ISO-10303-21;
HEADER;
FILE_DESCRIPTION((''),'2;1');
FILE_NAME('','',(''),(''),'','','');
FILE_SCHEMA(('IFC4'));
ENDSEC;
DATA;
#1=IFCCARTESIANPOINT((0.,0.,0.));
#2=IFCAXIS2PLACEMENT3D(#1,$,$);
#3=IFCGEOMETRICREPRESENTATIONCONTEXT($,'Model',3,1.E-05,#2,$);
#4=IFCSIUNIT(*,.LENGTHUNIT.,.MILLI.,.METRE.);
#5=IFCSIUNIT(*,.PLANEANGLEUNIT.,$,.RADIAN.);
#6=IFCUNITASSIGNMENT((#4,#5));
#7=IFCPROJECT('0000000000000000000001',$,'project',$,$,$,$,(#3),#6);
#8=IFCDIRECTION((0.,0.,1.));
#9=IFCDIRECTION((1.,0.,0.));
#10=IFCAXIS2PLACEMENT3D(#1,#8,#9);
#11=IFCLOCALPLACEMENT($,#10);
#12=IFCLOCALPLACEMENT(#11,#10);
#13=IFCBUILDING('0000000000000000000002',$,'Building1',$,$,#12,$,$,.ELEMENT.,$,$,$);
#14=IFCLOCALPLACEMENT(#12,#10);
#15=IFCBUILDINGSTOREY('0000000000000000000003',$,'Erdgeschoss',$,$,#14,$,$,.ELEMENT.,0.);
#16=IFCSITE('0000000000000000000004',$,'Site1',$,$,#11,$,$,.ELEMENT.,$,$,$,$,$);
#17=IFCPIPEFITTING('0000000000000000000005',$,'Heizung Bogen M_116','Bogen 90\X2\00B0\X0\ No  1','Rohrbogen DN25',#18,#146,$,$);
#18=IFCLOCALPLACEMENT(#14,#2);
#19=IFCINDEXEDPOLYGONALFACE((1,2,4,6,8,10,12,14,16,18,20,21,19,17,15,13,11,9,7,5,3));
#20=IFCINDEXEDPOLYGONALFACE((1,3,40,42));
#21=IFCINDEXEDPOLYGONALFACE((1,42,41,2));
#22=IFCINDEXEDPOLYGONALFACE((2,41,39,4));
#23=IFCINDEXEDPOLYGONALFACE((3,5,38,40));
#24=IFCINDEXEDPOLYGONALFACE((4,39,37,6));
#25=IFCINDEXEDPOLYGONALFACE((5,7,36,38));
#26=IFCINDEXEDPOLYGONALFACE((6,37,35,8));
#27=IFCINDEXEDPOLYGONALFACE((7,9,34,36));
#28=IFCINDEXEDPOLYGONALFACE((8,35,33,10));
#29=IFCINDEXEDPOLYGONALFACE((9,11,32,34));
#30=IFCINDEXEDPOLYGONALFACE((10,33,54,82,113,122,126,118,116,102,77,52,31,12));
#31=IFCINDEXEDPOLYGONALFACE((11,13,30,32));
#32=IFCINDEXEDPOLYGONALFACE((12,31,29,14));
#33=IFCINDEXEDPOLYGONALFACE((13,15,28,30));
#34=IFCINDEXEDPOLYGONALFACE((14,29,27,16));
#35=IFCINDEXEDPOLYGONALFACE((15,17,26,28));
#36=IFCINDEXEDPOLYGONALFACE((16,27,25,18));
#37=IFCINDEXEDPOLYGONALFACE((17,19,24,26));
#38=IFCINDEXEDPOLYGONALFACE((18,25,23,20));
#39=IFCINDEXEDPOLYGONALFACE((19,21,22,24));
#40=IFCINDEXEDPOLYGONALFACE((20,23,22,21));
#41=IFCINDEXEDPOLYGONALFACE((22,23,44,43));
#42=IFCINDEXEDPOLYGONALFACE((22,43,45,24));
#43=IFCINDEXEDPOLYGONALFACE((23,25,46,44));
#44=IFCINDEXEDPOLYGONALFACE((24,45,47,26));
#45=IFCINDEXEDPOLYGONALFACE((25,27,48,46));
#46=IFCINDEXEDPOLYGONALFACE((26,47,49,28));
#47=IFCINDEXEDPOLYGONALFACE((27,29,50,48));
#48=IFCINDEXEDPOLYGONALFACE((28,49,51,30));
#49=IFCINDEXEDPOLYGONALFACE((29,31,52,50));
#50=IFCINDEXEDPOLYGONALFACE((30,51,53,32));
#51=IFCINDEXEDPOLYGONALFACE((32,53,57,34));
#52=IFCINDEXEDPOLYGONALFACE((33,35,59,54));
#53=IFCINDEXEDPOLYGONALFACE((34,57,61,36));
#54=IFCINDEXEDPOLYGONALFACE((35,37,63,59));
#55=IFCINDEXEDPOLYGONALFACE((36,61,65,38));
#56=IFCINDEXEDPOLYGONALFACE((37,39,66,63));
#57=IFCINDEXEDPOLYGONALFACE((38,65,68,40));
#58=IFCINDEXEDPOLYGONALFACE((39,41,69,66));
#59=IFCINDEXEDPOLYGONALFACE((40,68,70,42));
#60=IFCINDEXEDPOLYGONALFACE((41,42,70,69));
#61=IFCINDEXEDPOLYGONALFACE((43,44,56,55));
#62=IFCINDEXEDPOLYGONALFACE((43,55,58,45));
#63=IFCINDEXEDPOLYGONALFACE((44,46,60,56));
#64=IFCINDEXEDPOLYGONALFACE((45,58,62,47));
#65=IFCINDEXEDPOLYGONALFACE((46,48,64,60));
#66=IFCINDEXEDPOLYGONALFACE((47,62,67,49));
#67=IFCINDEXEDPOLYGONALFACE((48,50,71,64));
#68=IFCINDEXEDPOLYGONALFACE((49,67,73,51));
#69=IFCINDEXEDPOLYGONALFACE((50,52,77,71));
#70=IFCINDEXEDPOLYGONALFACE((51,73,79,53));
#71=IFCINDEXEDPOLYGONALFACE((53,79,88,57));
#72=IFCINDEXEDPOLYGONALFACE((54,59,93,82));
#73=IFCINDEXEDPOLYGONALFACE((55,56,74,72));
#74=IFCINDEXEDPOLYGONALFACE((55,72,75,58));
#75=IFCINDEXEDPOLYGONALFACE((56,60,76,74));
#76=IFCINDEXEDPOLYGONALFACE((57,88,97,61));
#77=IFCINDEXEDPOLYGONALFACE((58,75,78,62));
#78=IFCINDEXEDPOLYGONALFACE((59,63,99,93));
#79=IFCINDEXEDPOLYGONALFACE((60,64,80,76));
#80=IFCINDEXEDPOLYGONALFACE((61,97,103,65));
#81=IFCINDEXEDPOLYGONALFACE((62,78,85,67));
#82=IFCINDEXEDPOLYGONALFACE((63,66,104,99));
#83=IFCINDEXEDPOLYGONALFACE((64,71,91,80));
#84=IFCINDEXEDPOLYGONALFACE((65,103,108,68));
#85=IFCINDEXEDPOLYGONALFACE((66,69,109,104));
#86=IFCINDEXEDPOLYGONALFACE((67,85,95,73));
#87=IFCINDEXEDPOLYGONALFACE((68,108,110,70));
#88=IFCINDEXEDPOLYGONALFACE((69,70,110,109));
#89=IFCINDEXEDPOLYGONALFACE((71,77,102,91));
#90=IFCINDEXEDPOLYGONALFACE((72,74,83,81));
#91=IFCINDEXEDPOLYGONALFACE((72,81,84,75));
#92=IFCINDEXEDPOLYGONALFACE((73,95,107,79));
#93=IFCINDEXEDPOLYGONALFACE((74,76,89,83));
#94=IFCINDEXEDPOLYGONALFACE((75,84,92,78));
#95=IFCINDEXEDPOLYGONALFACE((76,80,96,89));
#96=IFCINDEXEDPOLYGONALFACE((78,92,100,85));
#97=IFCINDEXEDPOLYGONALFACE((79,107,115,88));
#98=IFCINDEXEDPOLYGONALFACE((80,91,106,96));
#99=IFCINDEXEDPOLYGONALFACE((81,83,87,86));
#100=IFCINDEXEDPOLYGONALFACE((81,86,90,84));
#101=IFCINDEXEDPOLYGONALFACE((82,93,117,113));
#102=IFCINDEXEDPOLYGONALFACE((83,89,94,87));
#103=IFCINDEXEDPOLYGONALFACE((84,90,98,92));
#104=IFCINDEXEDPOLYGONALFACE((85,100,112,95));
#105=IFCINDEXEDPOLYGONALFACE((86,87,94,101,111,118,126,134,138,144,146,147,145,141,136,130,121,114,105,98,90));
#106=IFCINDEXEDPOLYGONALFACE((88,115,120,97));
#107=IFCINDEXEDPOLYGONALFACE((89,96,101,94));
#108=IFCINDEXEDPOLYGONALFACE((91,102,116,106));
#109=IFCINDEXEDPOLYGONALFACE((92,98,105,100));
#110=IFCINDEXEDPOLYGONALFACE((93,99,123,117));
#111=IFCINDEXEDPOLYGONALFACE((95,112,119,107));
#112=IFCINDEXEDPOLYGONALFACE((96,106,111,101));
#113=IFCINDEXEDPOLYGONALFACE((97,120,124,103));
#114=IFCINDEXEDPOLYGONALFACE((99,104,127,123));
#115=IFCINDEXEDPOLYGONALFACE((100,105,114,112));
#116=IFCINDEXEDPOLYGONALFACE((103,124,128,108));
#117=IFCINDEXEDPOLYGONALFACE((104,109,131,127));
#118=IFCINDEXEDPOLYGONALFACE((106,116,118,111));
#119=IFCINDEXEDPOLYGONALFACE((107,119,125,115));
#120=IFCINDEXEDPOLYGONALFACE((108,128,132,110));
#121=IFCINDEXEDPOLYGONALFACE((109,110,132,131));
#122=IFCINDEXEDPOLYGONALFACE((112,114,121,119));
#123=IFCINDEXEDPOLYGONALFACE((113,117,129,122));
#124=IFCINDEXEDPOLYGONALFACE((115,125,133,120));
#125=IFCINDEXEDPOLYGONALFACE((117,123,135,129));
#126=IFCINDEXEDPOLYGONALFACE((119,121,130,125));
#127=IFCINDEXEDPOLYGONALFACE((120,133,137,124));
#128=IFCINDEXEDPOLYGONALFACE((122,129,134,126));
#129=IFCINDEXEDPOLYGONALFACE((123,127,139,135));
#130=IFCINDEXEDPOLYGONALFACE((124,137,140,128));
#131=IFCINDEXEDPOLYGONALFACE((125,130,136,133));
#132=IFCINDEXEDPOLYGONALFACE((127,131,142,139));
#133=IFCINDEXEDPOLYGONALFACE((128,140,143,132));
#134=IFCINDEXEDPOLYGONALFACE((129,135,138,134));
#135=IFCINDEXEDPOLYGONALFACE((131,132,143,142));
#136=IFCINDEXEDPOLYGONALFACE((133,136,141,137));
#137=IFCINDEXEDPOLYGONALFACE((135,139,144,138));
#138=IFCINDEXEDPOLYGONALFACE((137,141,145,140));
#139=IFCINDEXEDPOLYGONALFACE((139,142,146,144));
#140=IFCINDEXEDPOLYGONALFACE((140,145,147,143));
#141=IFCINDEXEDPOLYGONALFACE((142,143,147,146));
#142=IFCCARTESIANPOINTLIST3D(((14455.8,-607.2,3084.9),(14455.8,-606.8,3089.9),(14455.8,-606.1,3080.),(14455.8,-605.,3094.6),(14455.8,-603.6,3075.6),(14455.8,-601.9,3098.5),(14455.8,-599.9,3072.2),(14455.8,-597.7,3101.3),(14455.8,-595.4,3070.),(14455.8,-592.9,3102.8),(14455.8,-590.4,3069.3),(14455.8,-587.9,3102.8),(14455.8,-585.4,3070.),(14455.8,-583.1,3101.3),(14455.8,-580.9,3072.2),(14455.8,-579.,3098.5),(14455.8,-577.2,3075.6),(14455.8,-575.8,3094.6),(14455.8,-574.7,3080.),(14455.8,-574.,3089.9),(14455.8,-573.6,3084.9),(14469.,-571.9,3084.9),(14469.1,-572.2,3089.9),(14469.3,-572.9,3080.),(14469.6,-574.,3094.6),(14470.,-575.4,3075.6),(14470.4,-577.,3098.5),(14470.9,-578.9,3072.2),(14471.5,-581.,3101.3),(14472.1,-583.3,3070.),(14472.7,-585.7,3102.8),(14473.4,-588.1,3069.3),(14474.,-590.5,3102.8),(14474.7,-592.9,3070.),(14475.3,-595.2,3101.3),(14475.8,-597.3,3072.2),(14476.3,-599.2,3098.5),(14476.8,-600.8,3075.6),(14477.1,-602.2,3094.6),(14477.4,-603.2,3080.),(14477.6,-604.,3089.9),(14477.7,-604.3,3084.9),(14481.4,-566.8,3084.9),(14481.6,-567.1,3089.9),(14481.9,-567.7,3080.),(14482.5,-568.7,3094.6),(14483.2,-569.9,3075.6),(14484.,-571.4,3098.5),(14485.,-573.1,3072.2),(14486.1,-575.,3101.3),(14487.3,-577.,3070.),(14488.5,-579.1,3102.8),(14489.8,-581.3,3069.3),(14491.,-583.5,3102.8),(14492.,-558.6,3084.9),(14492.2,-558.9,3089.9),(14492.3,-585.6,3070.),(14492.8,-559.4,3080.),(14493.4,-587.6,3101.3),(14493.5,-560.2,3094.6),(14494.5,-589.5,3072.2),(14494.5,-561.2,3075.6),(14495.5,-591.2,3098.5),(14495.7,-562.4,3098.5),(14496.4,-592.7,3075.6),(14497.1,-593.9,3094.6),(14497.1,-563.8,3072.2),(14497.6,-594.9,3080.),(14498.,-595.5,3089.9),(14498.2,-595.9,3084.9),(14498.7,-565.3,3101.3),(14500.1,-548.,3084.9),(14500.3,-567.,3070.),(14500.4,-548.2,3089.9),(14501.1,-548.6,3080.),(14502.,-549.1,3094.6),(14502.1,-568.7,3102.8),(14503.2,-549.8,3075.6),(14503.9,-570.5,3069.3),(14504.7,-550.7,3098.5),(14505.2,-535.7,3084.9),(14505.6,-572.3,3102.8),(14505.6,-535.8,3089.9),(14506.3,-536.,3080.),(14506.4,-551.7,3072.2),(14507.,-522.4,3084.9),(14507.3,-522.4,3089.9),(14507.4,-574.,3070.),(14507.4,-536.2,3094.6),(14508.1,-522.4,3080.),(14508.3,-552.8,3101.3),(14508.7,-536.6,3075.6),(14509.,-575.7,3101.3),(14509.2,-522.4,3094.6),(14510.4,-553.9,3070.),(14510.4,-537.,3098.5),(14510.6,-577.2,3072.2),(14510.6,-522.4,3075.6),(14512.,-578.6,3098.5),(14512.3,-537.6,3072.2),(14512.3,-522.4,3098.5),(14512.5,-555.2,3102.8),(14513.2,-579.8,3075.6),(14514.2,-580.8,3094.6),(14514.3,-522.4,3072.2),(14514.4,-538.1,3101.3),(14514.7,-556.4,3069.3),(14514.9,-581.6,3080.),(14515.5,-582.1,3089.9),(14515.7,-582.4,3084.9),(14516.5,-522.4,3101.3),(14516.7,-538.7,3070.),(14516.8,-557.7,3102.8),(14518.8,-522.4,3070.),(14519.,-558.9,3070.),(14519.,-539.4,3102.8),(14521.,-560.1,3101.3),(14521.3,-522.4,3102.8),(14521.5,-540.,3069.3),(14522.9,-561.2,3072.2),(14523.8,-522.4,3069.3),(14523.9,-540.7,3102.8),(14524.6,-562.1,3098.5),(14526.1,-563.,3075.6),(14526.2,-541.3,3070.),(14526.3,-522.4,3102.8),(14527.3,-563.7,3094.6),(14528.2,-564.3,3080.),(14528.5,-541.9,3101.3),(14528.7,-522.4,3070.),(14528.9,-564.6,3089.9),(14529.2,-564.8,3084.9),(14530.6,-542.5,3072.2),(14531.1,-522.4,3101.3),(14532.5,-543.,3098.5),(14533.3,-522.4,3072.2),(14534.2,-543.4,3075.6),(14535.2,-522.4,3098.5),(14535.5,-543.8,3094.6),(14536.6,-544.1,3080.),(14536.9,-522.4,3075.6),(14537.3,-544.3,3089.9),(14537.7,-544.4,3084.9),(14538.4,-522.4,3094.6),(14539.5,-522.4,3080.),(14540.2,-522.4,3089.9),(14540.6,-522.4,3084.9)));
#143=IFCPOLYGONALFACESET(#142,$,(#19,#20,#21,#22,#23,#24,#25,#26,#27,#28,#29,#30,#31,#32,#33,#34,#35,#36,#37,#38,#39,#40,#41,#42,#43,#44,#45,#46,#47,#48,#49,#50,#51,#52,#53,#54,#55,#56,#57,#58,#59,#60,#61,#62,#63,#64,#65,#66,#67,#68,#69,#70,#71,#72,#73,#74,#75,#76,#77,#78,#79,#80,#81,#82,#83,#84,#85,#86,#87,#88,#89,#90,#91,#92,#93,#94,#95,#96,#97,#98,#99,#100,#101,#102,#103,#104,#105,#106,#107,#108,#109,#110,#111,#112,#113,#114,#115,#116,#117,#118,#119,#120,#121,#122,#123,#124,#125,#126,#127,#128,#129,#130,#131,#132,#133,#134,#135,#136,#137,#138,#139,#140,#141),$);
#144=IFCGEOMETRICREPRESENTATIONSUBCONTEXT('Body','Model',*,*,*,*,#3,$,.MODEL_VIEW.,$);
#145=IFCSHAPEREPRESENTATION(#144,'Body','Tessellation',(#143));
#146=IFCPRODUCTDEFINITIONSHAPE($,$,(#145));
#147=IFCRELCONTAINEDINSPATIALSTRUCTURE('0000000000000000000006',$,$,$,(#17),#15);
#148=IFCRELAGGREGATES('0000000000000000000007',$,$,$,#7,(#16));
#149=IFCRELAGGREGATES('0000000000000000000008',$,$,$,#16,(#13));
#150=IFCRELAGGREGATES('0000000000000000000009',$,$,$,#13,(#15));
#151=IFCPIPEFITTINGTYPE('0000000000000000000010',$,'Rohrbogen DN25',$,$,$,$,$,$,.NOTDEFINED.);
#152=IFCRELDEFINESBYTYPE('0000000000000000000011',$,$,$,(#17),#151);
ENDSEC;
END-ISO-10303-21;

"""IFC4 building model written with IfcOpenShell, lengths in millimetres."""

from ifc_helpers import new_model, entity, si_unit, frame, origin, origin_with_axes, place, context, subcontext, project, spatial, source, transform, mapped, type_object, element, save


model = new_model("IFC4")

# Units and contexts
model_context = context("Model", 3, precision=1e-05, world=origin())
body_context = subcontext(model_context, "Body", "Model", "MODEL_VIEW")
ifc_project = project(units=[si_unit("LENGTHUNIT", "METRE", prefix="MILLI"), si_unit("PLANEANGLEUNIT", "RADIAN")], contexts=[model_context])

# Site, building, storey
site_placement = place(None, origin_with_axes())
site = spatial("IfcSite", under=ifc_project, at=site_placement, Name="Site1", CompositionType="ELEMENT")
building_placement = place(site_placement, origin_with_axes())
building = spatial("IfcBuilding", under=site, at=building_placement, Name="Building1", CompositionType="ELEMENT")
storey_placement = place(building_placement, origin_with_axes())
storey = spatial("IfcBuildingStorey", under=building, at=storey_placement, Name="Erdgeschoss", CompositionType="ELEMENT", Elevation=0.0)

# Pipe fitting
pipe_fitting_type = type_object("IfcPipeFittingType", Name="Rohrbogen DN25", PredefinedType="NOTDEFINED")
shared_shape_1 = source(origin_with_axes(), body_context, "Body", "SolidModel", [
    entity("IfcRevolvedAreaSolid", entity("IfcCircleProfileDef", "AREA", None, entity("IfcAxis2Placement2D", entity("IfcCartesianPoint", [0.0, 0.0]), entity("IfcDirection", [1.0, 0.0])), 16.9), entity("IfcAxis2Placement3D", entity("IfcCartesianPoint", [-42.4, 25.6, 0.0]), entity("IfcDirection", [1.0, 0.0, 0.0]), entity("IfcDirection", [0.0, 0.0, 1.0])), entity("IfcAxis1Placement", entity("IfcCartesianPoint", [0.0, 68.0, 0.0]), entity("IfcDirection", [-1.0, 0.0, 0.0])), 1.570796),
])
pipe_fitting_1_placement = place(storey_placement, frame((14498.2, -564.8, 3086.1), z_axis=(0.0, 0.0, 1.0), x_axis=(1.0, 0.0, 0.0)))
element("IfcPipeFitting", 1, at=pipe_fitting_1_placement, inside=storey, type_object=pipe_fitting_type, Name="Heizung Bogen M_116", Description="Bogen 90° No  1", ObjectType="Rohrbogen DN25", context=body_context, shape_type="MappedRepresentation", body=[
    mapped(shared_shape_1, transform((0.0, 0.0, 0.0), x_axis=(1.0, 0.0, 0.0), y_axis=(0.0, -1.0, 0.0), z_axis=(0.0, 0.0, -1.0), scale=1.0)),
])

save(model, "model.ifc")
